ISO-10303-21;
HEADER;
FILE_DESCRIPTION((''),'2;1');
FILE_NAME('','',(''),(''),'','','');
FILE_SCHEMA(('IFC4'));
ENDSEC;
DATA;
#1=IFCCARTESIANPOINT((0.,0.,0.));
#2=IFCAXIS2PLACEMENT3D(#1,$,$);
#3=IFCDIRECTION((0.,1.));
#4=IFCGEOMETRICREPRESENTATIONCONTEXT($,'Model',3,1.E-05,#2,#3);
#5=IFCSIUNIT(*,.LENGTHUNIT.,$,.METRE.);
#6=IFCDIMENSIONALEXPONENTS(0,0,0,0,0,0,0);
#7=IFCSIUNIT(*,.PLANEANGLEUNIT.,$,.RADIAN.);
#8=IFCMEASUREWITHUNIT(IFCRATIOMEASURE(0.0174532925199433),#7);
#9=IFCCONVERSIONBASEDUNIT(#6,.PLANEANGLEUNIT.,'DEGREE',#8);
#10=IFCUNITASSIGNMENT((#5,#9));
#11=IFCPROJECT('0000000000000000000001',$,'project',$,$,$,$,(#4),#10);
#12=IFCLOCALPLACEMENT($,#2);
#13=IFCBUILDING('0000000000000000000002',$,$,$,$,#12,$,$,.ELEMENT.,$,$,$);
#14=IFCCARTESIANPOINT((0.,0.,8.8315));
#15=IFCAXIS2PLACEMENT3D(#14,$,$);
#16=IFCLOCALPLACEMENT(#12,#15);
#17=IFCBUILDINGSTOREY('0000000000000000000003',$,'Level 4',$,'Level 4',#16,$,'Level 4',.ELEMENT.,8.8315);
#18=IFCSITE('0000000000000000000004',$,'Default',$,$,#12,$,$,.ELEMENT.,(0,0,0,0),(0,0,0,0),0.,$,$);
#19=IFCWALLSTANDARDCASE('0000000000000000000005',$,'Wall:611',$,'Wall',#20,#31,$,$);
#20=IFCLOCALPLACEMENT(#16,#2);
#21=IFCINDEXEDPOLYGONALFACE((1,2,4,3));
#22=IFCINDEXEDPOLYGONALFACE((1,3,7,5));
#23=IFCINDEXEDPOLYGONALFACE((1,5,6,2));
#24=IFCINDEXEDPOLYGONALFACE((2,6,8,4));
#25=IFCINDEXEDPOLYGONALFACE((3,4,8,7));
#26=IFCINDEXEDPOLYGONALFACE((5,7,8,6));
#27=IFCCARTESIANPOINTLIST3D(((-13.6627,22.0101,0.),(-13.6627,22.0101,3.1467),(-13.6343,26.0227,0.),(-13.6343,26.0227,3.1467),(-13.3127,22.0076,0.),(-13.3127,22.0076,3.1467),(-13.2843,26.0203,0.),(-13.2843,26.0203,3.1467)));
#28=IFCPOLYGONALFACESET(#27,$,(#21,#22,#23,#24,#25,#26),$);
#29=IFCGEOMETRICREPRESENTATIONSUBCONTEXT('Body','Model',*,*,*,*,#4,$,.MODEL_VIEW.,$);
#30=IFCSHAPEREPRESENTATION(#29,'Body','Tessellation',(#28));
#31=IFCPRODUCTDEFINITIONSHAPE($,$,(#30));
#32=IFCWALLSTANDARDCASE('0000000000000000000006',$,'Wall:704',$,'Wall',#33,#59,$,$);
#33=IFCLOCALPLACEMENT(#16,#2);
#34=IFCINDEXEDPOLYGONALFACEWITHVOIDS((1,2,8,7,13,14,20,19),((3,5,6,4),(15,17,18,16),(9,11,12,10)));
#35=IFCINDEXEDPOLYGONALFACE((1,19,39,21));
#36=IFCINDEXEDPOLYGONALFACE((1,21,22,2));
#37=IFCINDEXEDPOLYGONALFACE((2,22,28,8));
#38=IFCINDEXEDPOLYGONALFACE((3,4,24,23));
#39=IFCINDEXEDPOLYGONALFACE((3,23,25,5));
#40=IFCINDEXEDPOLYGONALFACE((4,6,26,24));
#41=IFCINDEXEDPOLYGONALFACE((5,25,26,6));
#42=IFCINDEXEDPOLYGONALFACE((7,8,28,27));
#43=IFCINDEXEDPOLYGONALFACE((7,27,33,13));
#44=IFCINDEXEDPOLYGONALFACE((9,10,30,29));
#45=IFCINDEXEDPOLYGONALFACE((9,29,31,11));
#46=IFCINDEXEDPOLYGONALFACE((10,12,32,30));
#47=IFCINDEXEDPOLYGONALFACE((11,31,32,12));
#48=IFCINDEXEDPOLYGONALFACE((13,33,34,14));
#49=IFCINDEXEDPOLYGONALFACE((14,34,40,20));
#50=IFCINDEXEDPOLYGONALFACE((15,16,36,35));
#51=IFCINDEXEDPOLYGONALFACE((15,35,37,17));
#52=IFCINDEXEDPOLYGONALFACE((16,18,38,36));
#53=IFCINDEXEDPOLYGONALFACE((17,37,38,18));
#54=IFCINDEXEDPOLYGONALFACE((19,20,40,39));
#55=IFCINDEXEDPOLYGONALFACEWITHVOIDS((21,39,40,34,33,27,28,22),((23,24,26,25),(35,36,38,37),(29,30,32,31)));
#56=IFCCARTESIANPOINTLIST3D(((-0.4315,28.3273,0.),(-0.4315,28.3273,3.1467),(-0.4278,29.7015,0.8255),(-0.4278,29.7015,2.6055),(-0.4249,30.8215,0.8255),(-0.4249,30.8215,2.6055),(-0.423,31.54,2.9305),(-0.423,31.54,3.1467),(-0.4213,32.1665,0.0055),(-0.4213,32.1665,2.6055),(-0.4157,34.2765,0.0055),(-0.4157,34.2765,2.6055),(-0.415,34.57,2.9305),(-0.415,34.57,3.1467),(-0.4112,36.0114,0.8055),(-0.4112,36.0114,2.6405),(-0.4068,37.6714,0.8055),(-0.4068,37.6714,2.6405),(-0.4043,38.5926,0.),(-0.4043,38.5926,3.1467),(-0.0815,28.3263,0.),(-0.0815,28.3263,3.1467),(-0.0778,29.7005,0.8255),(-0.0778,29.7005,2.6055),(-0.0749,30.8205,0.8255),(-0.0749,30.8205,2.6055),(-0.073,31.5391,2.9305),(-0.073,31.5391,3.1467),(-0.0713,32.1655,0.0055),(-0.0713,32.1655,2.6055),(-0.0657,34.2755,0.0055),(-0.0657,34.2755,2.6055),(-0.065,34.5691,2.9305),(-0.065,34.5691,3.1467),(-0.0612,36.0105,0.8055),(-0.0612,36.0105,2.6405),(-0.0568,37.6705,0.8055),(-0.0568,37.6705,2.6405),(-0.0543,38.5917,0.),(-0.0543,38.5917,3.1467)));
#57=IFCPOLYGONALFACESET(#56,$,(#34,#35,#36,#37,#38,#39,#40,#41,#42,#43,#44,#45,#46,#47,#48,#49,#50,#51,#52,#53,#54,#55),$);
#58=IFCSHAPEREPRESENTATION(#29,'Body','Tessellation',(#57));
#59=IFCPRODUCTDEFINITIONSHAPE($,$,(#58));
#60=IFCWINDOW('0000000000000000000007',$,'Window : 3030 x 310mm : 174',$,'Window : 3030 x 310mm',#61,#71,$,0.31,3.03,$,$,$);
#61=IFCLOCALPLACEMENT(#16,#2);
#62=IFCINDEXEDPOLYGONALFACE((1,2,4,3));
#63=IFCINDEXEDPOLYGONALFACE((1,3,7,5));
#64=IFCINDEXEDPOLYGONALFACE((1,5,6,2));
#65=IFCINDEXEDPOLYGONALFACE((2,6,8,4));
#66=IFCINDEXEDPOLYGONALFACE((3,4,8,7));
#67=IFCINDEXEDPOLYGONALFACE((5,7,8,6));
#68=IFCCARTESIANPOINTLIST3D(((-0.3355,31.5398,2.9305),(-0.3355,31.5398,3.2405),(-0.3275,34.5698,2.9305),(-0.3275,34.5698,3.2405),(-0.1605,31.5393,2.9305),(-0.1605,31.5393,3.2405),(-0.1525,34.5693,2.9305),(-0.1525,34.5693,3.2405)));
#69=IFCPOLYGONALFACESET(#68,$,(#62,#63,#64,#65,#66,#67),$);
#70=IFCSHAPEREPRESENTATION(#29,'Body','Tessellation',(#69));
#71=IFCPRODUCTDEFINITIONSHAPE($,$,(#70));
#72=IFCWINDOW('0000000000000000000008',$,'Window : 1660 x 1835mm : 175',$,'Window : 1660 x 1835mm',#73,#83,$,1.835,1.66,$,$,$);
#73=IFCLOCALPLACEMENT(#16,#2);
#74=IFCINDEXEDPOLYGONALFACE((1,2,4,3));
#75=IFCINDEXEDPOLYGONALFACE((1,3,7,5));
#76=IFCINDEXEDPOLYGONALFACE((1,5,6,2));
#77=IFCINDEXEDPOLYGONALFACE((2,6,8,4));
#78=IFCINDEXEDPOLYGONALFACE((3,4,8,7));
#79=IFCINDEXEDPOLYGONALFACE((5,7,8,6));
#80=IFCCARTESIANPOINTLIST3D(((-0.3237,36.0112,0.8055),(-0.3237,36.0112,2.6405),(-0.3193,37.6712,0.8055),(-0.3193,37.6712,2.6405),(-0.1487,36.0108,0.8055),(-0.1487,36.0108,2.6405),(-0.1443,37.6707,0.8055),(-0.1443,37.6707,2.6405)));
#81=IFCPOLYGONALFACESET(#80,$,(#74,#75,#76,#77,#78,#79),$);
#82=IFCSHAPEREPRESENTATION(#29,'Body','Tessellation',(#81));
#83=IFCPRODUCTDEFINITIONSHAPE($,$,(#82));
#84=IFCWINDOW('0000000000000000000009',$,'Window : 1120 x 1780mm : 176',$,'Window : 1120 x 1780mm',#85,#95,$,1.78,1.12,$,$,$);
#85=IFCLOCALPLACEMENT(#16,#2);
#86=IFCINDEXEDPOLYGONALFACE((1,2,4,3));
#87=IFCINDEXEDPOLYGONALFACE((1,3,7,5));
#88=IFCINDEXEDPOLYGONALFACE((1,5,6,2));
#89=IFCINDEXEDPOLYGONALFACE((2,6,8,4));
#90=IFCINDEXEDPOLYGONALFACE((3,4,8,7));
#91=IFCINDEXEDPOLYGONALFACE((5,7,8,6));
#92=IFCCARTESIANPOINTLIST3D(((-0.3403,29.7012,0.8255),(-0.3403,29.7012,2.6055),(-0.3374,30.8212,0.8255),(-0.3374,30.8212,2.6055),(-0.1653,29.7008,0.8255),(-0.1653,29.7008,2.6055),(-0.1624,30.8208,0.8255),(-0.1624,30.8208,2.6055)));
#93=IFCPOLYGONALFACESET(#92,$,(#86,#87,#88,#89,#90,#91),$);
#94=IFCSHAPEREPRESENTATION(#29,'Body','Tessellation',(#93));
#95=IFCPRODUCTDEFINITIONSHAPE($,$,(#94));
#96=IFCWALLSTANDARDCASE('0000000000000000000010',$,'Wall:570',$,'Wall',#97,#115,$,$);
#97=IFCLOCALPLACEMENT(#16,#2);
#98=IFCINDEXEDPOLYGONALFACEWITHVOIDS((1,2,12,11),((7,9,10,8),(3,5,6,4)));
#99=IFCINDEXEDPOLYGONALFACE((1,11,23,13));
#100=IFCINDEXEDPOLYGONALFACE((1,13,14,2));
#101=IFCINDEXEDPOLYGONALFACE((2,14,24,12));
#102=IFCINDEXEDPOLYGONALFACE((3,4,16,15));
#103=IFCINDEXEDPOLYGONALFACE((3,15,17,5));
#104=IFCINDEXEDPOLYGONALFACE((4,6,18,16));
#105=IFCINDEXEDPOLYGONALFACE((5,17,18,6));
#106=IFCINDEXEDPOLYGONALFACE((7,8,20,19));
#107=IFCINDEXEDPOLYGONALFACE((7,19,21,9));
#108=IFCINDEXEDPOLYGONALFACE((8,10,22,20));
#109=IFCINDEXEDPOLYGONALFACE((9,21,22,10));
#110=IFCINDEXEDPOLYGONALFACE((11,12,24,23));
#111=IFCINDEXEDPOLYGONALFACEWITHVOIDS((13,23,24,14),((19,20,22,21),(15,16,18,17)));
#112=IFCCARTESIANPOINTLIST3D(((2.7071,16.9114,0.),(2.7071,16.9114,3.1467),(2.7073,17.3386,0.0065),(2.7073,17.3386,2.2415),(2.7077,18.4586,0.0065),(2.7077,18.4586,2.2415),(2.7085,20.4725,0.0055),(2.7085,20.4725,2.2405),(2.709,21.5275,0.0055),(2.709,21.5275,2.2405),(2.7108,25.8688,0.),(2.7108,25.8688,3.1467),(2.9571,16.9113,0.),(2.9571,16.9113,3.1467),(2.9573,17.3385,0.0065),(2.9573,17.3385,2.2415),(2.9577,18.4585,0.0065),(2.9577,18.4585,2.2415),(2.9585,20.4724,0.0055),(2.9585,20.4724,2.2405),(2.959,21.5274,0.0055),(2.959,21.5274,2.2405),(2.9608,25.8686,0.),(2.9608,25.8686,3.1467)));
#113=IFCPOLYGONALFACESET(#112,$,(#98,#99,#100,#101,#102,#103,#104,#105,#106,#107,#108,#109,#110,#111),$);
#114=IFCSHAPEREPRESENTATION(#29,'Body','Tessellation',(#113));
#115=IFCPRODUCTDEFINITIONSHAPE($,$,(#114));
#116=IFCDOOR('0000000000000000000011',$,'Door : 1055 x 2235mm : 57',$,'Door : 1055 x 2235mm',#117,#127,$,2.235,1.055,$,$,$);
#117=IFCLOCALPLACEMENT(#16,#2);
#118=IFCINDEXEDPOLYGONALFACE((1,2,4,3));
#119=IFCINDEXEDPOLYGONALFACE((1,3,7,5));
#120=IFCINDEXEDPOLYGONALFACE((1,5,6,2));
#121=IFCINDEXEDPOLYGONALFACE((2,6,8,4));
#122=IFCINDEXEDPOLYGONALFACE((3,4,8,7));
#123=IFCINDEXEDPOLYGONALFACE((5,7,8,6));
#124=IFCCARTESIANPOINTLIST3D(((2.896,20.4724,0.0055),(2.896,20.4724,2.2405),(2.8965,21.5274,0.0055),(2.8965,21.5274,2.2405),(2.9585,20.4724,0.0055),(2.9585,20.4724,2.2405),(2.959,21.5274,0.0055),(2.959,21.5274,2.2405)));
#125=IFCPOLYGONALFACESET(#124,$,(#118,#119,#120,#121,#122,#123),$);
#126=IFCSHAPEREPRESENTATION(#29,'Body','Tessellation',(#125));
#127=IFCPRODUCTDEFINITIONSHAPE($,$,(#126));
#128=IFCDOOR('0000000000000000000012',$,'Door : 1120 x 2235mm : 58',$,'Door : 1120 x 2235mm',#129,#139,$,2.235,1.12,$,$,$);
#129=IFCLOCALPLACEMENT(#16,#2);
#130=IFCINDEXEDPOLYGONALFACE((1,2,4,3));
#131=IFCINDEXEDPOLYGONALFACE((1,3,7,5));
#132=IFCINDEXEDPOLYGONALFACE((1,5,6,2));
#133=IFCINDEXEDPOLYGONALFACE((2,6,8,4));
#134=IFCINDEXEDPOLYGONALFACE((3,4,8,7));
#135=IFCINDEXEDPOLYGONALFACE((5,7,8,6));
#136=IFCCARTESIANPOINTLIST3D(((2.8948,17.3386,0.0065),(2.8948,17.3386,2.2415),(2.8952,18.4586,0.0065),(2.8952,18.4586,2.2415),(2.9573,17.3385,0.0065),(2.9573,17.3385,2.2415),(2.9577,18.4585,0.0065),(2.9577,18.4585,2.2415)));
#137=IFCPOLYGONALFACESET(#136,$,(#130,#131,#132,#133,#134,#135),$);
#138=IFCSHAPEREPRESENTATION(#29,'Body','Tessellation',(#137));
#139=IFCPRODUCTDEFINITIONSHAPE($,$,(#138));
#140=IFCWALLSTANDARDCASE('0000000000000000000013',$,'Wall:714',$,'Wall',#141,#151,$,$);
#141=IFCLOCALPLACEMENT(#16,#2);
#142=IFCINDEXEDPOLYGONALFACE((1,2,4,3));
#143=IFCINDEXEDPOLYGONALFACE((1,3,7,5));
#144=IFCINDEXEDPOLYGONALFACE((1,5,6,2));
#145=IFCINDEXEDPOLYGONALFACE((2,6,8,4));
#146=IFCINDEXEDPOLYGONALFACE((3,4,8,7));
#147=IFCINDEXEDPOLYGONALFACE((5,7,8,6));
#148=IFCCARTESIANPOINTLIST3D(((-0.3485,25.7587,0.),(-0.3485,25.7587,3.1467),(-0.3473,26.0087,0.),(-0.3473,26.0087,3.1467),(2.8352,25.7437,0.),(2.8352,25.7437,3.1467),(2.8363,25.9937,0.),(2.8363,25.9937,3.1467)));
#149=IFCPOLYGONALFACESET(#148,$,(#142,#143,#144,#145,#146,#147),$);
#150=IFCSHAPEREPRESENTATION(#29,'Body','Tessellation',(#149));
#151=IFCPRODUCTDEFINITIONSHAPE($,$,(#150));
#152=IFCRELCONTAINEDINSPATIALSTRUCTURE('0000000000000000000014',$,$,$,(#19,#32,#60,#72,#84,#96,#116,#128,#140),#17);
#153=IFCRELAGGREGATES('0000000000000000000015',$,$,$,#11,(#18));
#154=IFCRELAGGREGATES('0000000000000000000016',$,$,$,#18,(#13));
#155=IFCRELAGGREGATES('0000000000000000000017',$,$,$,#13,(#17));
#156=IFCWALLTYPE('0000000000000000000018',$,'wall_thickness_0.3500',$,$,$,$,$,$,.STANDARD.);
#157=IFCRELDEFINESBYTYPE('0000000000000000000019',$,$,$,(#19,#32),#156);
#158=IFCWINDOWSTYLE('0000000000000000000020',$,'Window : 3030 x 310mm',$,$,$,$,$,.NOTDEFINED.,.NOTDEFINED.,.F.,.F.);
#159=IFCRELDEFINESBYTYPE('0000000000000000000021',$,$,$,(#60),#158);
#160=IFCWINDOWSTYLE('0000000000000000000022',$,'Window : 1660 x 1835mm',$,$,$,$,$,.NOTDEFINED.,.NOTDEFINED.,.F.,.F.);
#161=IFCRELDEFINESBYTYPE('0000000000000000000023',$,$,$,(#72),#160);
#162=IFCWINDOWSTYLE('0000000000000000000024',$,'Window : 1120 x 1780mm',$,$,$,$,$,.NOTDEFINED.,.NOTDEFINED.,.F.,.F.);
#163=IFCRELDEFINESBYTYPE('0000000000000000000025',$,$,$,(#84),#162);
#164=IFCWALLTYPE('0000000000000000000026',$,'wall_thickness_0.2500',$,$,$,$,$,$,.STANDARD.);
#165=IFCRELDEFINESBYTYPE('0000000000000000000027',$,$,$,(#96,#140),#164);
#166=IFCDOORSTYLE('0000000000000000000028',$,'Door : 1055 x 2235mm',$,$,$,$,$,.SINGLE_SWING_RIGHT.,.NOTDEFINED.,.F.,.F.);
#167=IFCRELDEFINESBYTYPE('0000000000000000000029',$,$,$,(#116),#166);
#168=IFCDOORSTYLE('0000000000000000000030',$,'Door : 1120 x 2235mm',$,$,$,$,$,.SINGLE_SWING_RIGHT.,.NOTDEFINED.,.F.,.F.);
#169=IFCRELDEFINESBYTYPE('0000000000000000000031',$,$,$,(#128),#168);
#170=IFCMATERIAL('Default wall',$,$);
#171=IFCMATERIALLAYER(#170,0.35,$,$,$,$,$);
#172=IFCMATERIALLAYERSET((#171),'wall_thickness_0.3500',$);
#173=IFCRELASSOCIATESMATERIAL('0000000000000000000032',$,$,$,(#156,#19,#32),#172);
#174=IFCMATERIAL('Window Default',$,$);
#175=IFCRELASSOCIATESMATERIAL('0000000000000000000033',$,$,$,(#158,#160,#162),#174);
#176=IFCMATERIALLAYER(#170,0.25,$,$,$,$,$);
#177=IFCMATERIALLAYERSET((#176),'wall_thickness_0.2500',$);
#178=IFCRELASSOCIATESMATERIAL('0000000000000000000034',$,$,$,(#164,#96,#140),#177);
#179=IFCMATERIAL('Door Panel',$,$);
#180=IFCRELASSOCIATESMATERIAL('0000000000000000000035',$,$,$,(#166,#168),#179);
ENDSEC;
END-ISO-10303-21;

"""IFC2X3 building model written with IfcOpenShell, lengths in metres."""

from ifc_helpers import new_model, entity, si_unit, converted_unit, direction, frame, frame_2d, origin, origin_2d_with_axis, place, context, subcontext, project, spatial, polyline, rectangle, outline, extrude, source, transform, mapped, material, layer, layer_set, layer_usage, type_object, type_shapes, element, fill, save


model = new_model("IFC2X3")

# Units and contexts
model_context = context("Model", 3, precision=1e-05, world=origin(), true_north=direction((0.0, 1.0)))
body_context = subcontext(model_context, "Body", "Model", "MODEL_VIEW")
ifc_project = project(units=[si_unit("LENGTHUNIT", "METRE"), converted_unit("PLANEANGLEUNIT", "DEGREE", entity("IfcRatioMeasure", 0.0174532925199433), si_unit("PLANEANGLEUNIT", "RADIAN"), dimensions=[0, 0, 0, 0, 0, 0, 0])], contexts=[model_context])

# Site, building, storey
placement_1 = place(None, origin())
site = spatial("IfcSite", under=ifc_project, at=placement_1, Name="Default", CompositionType="ELEMENT", RefLatitude=(0, 0, 0, 0), RefLongitude=(0, 0, 0, 0), RefElevation=0.0)
building = spatial("IfcBuilding", under=site, at=placement_1, CompositionType="ELEMENT")
storey_placement = place(placement_1, frame((0.0, 0.0, 8.8315)))
storey = spatial("IfcBuildingStorey", under=building, at=storey_placement, Name="Level 4", ObjectType="Level 4", LongName="Level 4", CompositionType="ELEMENT", Elevation=8.8315)

# Wall
ifc_material_1 = material(Name="Default wall")
ifc_layer_1 = layer(ifc_material_1, 0.35)
ifc_layer_set_1 = layer_set([ifc_layer_1], Name="wall_thickness_0.3500")
ifc_layer_usage_1 = layer_usage(ifc_layer_set_1, "AXIS2", "POSITIVE", -0.175)
wall_type_1 = type_object("IfcWallType", Name="wall_thickness_0.3500", PredefinedType="STANDARD", material=ifc_layer_set_1)
wall_1_placement = place(storey_placement, frame((-13.4593, 26.0215, 0.0), z_axis=(0.0, 0.0, 1.0), x_axis=(-0.007085, -0.999975, 0.0)))
element("IfcWallStandardCase", 1, at=wall_1_placement, inside=storey, type_object=wall_type_1, material=ifc_layer_usage_1, Name="Wall:611", ObjectType="Wall", context=body_context, shape_type="SweptSolid", body=[
    extrude(outline(polyline([(4.0128, -0.175), (4.0128, 0.175), (0.0, 0.175), (0.0, -0.175), (4.0128, -0.175)])), origin(), (0.0, 0.0, 1.0), 3.1467),
])

# Wall, openings, windows
wall_2_placement = place(storey_placement, frame((-0.2293, 38.5922, 0.0), z_axis=(0.0, 0.0, 1.0), x_axis=(-0.002644, -0.999997, 0.0)))
wall_2 = element("IfcWallStandardCase", 2, at=wall_2_placement, inside=storey, type_object=wall_type_1, material=ifc_layer_usage_1, Name="Wall:704", ObjectType="Wall", context=body_context, shape_type="SweptSolid", body=[
    extrude(outline(polyline([(10.2654, -0.175), (10.2654, 0.175), (0.0, 0.175), (0.0, -0.175), (10.2654, -0.175)])), origin(), (0.0, 0.0, 1.0), 3.1467),
])
opening_1_placement = place(wall_2_placement, frame((4.3162, -0.175, 0.0055)))
element("IfcOpeningElement", 3, at=opening_1_placement, cuts=wall_2, ObjectType="Opening", context=body_context, shape_type="SweptSolid", body=[
    extrude(rectangle(XDim=2.11, YDim=2.6, at=frame_2d((1.3, 1.055), x_axis=(0.0, 1.0))), frame((0.0, 0.0, 0.0), z_axis=(0.0, 1.0, 0.0), x_axis=(0.0, 0.0, 1.0)), (0.0, 0.0, 1.0), 0.35),
])
opening_2_placement = place(wall_2_placement, frame((4.0226, -0.175, 2.9305)))
opening_2 = element("IfcOpeningElement", 4, at=opening_2_placement, cuts=wall_2, ObjectType="Opening", context=body_context, shape_type="SweptSolid", body=[
    extrude(rectangle(XDim=3.03, YDim=0.31, at=frame_2d((0.155, 1.515), x_axis=(0.0, 1.0))), frame((0.0, 0.0, 0.0), z_axis=(0.0, 1.0, 0.0), x_axis=(0.0, 0.0, 1.0)), (0.0, 0.0, 1.0), 0.35),
])
opening_3_placement = place(wall_2_placement, frame((0.9212, -0.175, 0.8055)))
opening_3 = element("IfcOpeningElement", 5, at=opening_3_placement, cuts=wall_2, ObjectType="Opening", context=body_context, shape_type="SweptSolid", body=[
    extrude(rectangle(XDim=1.66, YDim=1.835, at=frame_2d((0.9175, 0.83), x_axis=(0.0, 1.0))), frame((0.0, 0.0, 0.0), z_axis=(0.0, 1.0, 0.0), x_axis=(0.0, 0.0, 1.0)), (0.0, 0.0, 1.0), 0.35),
])
opening_4_placement = place(wall_2_placement, frame((7.7712, -0.175, 0.8255)))
opening_4 = element("IfcOpeningElement", 6, at=opening_4_placement, cuts=wall_2, ObjectType="Opening", context=body_context, shape_type="SweptSolid", body=[
    extrude(rectangle(XDim=1.12, YDim=1.78, at=frame_2d((0.89, 0.56), x_axis=(0.0, 1.0))), frame((0.0, 0.0, 0.0), z_axis=(0.0, 1.0, 0.0), x_axis=(0.0, 0.0, 1.0)), (0.0, 0.0, 1.0), 0.35),
])
ifc_material_2 = material(Name="Window Default")
window_style_1 = type_object("IfcWindowStyle", Name="Window : 3030 x 310mm", ConstructionType="NOTDEFINED", OperationType="NOTDEFINED", ParameterTakesPrecedence=False, Sizeable=False, material=ifc_material_2)
shared_shape_1 = source(origin(), body_context, "Body", "SweptSolid", [
    extrude(rectangle(XDim=0.175, YDim=3.03, at=origin_2d_with_axis()), frame((1.515, 0.175, 0.0), z_axis=(0.0, 0.0, 1.0), x_axis=(0.0, 1.0, 0.0)), (0.0, 0.0, 1.0), 0.31),
])
type_shapes(window_style_1, [shared_shape_1])
window_1_placement = place(opening_2_placement, origin())
window_1 = element("IfcWindow", 7, at=window_1_placement, inside=storey, type_object=window_style_1, Name="Window : 3030 x 310mm : 174", ObjectType="Window : 3030 x 310mm", OverallHeight=0.31, OverallWidth=3.03, context=body_context, shape_type="MappedRepresentation", body=[
    mapped(shared_shape_1, transform((0.0, 0.0, 0.0), scale=1.0)),
])
fill(opening_2, window_1)
window_style_2 = type_object("IfcWindowStyle", Name="Window : 1660 x 1835mm", ConstructionType="NOTDEFINED", OperationType="NOTDEFINED", ParameterTakesPrecedence=False, Sizeable=False, material=ifc_material_2)
shared_shape_2 = source(origin(), body_context, "Body", "SweptSolid", [
    extrude(rectangle(XDim=0.175, YDim=1.66, at=origin_2d_with_axis()), frame((0.83, 0.175, 0.0), z_axis=(0.0, 0.0, 1.0), x_axis=(0.0, 1.0, 0.0)), (0.0, 0.0, 1.0), 1.835),
])
type_shapes(window_style_2, [shared_shape_2])
window_2_placement = place(opening_3_placement, origin())
window_2 = element("IfcWindow", 8, at=window_2_placement, inside=storey, type_object=window_style_2, Name="Window : 1660 x 1835mm : 175", ObjectType="Window : 1660 x 1835mm", OverallHeight=1.835, OverallWidth=1.66, context=body_context, shape_type="MappedRepresentation", body=[
    mapped(shared_shape_2, transform((0.0, 0.0, 0.0), scale=1.0)),
])
fill(opening_3, window_2)
window_style_3 = type_object("IfcWindowStyle", Name="Window : 1120 x 1780mm", ConstructionType="NOTDEFINED", OperationType="NOTDEFINED", ParameterTakesPrecedence=False, Sizeable=False, material=ifc_material_2)
shared_shape_3 = source(origin(), body_context, "Body", "SweptSolid", [
    extrude(rectangle(XDim=0.175, YDim=1.12, at=origin_2d_with_axis()), frame((0.56, 0.175, 0.0), z_axis=(0.0, 0.0, 1.0), x_axis=(0.0, 1.0, 0.0)), (0.0, 0.0, 1.0), 1.78),
])
type_shapes(window_style_3, [shared_shape_3])
window_3_placement = place(opening_4_placement, origin())
window_3 = element("IfcWindow", 9, at=window_3_placement, inside=storey, type_object=window_style_3, Name="Window : 1120 x 1780mm : 176", ObjectType="Window : 1120 x 1780mm", OverallHeight=1.78, OverallWidth=1.12, context=body_context, shape_type="MappedRepresentation", body=[
    mapped(shared_shape_3, transform((0.0, 0.0, 0.0), scale=1.0)),
])
fill(opening_4, window_3)

# Wall, openings, doors
ifc_layer_2 = layer(ifc_material_1, 0.25)
ifc_layer_set_2 = layer_set([ifc_layer_2], Name="wall_thickness_0.2500")
ifc_layer_usage_2 = layer_usage(ifc_layer_set_2, "AXIS2", "POSITIVE", -0.125)
wall_type_2 = type_object("IfcWallType", Name="wall_thickness_0.2500", PredefinedType="STANDARD", material=ifc_layer_set_2)
wall_3_placement = place(storey_placement, frame((2.8358, 25.8687, 0.0), z_axis=(0.0, 0.0, 1.0), x_axis=(-0.000411, -1.0, 0.0)))
wall_3 = element("IfcWallStandardCase", 10, at=wall_3_placement, inside=storey, type_object=wall_type_2, material=ifc_layer_usage_2, Name="Wall:570", ObjectType="Wall", context=body_context, shape_type="SweptSolid", body=[
    extrude(outline(polyline([(8.9574, -0.125), (8.9574, 0.125), (0.0, 0.125), (0.0, -0.125), (8.9574, -0.125)])), origin(), (0.0, 0.0, 1.0), 3.1467),
])
opening_5_placement = place(wall_3_placement, frame((4.3413, -0.125, 0.0055)))
opening_5 = element("IfcOpeningElement", 11, at=opening_5_placement, cuts=wall_3, ObjectType="Opening", context=body_context, shape_type="SweptSolid", body=[
    extrude(rectangle(XDim=1.055, YDim=2.235, at=frame_2d((1.1175, 0.5275), x_axis=(0.0, 1.0))), frame((0.0, 0.0, 0.0), z_axis=(0.0, 1.0, 0.0), x_axis=(0.0, 0.0, 1.0)), (0.0, 0.0, 1.0), 0.25),
])
opening_6_placement = place(wall_3_placement, frame((7.4101, -0.125, 0.0065)))
opening_6 = element("IfcOpeningElement", 12, at=opening_6_placement, cuts=wall_3, ObjectType="Opening", context=body_context, shape_type="SweptSolid", body=[
    extrude(rectangle(XDim=1.12, YDim=2.235, at=frame_2d((1.1175, 0.56), x_axis=(0.0, 1.0))), frame((0.0, 0.0, 0.0), z_axis=(0.0, 1.0, 0.0), x_axis=(0.0, 0.0, 1.0)), (0.0, 0.0, 1.0), 0.25),
])
ifc_material_3 = material(Name="Door Panel")
door_style_1 = type_object("IfcDoorStyle", Name="Door : 1055 x 2235mm", ConstructionType="NOTDEFINED", OperationType="SINGLE_SWING_RIGHT", ParameterTakesPrecedence=False, Sizeable=False, material=ifc_material_3)
shared_shape_4 = source(origin(), body_context, "Body", "SweptSolid", [
    extrude(rectangle(XDim=0.0625, YDim=1.055, at=origin_2d_with_axis()), frame((0.5275, 0.2188, 0.0), z_axis=(0.0, 0.0, 1.0), x_axis=(0.0, 1.0, 0.0)), (0.0, 0.0, 1.0), 2.235),
])
type_shapes(door_style_1, [shared_shape_4])
door_1_placement = place(opening_5_placement, origin())
door_1 = element("IfcDoor", 13, at=door_1_placement, inside=storey, type_object=door_style_1, Name="Door : 1055 x 2235mm : 57", ObjectType="Door : 1055 x 2235mm", OverallHeight=2.235, OverallWidth=1.055, context=body_context, shape_type="MappedRepresentation", body=[
    mapped(shared_shape_4, transform((0.0, 0.0, 0.0), scale=1.0)),
])
fill(opening_5, door_1)
door_style_2 = type_object("IfcDoorStyle", Name="Door : 1120 x 2235mm", ConstructionType="NOTDEFINED", OperationType="SINGLE_SWING_RIGHT", ParameterTakesPrecedence=False, Sizeable=False, material=ifc_material_3)
shared_shape_5 = source(origin(), body_context, "Body", "SweptSolid", [
    extrude(rectangle(XDim=0.0625, YDim=1.12, at=origin_2d_with_axis()), frame((0.56, 0.2188, 0.0), z_axis=(0.0, 0.0, 1.0), x_axis=(0.0, 1.0, 0.0)), (0.0, 0.0, 1.0), 2.235),
])
type_shapes(door_style_2, [shared_shape_5])
door_2_placement = place(opening_6_placement, origin())
door_2 = element("IfcDoor", 14, at=door_2_placement, inside=storey, type_object=door_style_2, Name="Door : 1120 x 2235mm : 58", ObjectType="Door : 1120 x 2235mm", OverallHeight=2.235, OverallWidth=1.12, context=body_context, shape_type="MappedRepresentation", body=[
    mapped(shared_shape_5, transform((0.0, 0.0, 0.0), scale=1.0)),
])
fill(opening_6, door_2)

# Wall
wall_4_placement = place(storey_placement, frame((-0.3479, 25.8837, 0.0), z_axis=(0.0, 0.0, 1.0), x_axis=(0.999989, -0.004706, 0.0)))
element("IfcWallStandardCase", 15, at=wall_4_placement, inside=storey, type_object=wall_type_2, material=ifc_layer_usage_2, Name="Wall:714", ObjectType="Wall", context=body_context, shape_type="SweptSolid", body=[
    extrude(outline(polyline([(3.1837, -0.125), (3.1837, 0.125), (0.0, 0.125), (0.0, -0.125), (3.1837, -0.125)])), origin(), (0.0, 0.0, 1.0), 3.1467),
])

save(model, "model.ifc")
